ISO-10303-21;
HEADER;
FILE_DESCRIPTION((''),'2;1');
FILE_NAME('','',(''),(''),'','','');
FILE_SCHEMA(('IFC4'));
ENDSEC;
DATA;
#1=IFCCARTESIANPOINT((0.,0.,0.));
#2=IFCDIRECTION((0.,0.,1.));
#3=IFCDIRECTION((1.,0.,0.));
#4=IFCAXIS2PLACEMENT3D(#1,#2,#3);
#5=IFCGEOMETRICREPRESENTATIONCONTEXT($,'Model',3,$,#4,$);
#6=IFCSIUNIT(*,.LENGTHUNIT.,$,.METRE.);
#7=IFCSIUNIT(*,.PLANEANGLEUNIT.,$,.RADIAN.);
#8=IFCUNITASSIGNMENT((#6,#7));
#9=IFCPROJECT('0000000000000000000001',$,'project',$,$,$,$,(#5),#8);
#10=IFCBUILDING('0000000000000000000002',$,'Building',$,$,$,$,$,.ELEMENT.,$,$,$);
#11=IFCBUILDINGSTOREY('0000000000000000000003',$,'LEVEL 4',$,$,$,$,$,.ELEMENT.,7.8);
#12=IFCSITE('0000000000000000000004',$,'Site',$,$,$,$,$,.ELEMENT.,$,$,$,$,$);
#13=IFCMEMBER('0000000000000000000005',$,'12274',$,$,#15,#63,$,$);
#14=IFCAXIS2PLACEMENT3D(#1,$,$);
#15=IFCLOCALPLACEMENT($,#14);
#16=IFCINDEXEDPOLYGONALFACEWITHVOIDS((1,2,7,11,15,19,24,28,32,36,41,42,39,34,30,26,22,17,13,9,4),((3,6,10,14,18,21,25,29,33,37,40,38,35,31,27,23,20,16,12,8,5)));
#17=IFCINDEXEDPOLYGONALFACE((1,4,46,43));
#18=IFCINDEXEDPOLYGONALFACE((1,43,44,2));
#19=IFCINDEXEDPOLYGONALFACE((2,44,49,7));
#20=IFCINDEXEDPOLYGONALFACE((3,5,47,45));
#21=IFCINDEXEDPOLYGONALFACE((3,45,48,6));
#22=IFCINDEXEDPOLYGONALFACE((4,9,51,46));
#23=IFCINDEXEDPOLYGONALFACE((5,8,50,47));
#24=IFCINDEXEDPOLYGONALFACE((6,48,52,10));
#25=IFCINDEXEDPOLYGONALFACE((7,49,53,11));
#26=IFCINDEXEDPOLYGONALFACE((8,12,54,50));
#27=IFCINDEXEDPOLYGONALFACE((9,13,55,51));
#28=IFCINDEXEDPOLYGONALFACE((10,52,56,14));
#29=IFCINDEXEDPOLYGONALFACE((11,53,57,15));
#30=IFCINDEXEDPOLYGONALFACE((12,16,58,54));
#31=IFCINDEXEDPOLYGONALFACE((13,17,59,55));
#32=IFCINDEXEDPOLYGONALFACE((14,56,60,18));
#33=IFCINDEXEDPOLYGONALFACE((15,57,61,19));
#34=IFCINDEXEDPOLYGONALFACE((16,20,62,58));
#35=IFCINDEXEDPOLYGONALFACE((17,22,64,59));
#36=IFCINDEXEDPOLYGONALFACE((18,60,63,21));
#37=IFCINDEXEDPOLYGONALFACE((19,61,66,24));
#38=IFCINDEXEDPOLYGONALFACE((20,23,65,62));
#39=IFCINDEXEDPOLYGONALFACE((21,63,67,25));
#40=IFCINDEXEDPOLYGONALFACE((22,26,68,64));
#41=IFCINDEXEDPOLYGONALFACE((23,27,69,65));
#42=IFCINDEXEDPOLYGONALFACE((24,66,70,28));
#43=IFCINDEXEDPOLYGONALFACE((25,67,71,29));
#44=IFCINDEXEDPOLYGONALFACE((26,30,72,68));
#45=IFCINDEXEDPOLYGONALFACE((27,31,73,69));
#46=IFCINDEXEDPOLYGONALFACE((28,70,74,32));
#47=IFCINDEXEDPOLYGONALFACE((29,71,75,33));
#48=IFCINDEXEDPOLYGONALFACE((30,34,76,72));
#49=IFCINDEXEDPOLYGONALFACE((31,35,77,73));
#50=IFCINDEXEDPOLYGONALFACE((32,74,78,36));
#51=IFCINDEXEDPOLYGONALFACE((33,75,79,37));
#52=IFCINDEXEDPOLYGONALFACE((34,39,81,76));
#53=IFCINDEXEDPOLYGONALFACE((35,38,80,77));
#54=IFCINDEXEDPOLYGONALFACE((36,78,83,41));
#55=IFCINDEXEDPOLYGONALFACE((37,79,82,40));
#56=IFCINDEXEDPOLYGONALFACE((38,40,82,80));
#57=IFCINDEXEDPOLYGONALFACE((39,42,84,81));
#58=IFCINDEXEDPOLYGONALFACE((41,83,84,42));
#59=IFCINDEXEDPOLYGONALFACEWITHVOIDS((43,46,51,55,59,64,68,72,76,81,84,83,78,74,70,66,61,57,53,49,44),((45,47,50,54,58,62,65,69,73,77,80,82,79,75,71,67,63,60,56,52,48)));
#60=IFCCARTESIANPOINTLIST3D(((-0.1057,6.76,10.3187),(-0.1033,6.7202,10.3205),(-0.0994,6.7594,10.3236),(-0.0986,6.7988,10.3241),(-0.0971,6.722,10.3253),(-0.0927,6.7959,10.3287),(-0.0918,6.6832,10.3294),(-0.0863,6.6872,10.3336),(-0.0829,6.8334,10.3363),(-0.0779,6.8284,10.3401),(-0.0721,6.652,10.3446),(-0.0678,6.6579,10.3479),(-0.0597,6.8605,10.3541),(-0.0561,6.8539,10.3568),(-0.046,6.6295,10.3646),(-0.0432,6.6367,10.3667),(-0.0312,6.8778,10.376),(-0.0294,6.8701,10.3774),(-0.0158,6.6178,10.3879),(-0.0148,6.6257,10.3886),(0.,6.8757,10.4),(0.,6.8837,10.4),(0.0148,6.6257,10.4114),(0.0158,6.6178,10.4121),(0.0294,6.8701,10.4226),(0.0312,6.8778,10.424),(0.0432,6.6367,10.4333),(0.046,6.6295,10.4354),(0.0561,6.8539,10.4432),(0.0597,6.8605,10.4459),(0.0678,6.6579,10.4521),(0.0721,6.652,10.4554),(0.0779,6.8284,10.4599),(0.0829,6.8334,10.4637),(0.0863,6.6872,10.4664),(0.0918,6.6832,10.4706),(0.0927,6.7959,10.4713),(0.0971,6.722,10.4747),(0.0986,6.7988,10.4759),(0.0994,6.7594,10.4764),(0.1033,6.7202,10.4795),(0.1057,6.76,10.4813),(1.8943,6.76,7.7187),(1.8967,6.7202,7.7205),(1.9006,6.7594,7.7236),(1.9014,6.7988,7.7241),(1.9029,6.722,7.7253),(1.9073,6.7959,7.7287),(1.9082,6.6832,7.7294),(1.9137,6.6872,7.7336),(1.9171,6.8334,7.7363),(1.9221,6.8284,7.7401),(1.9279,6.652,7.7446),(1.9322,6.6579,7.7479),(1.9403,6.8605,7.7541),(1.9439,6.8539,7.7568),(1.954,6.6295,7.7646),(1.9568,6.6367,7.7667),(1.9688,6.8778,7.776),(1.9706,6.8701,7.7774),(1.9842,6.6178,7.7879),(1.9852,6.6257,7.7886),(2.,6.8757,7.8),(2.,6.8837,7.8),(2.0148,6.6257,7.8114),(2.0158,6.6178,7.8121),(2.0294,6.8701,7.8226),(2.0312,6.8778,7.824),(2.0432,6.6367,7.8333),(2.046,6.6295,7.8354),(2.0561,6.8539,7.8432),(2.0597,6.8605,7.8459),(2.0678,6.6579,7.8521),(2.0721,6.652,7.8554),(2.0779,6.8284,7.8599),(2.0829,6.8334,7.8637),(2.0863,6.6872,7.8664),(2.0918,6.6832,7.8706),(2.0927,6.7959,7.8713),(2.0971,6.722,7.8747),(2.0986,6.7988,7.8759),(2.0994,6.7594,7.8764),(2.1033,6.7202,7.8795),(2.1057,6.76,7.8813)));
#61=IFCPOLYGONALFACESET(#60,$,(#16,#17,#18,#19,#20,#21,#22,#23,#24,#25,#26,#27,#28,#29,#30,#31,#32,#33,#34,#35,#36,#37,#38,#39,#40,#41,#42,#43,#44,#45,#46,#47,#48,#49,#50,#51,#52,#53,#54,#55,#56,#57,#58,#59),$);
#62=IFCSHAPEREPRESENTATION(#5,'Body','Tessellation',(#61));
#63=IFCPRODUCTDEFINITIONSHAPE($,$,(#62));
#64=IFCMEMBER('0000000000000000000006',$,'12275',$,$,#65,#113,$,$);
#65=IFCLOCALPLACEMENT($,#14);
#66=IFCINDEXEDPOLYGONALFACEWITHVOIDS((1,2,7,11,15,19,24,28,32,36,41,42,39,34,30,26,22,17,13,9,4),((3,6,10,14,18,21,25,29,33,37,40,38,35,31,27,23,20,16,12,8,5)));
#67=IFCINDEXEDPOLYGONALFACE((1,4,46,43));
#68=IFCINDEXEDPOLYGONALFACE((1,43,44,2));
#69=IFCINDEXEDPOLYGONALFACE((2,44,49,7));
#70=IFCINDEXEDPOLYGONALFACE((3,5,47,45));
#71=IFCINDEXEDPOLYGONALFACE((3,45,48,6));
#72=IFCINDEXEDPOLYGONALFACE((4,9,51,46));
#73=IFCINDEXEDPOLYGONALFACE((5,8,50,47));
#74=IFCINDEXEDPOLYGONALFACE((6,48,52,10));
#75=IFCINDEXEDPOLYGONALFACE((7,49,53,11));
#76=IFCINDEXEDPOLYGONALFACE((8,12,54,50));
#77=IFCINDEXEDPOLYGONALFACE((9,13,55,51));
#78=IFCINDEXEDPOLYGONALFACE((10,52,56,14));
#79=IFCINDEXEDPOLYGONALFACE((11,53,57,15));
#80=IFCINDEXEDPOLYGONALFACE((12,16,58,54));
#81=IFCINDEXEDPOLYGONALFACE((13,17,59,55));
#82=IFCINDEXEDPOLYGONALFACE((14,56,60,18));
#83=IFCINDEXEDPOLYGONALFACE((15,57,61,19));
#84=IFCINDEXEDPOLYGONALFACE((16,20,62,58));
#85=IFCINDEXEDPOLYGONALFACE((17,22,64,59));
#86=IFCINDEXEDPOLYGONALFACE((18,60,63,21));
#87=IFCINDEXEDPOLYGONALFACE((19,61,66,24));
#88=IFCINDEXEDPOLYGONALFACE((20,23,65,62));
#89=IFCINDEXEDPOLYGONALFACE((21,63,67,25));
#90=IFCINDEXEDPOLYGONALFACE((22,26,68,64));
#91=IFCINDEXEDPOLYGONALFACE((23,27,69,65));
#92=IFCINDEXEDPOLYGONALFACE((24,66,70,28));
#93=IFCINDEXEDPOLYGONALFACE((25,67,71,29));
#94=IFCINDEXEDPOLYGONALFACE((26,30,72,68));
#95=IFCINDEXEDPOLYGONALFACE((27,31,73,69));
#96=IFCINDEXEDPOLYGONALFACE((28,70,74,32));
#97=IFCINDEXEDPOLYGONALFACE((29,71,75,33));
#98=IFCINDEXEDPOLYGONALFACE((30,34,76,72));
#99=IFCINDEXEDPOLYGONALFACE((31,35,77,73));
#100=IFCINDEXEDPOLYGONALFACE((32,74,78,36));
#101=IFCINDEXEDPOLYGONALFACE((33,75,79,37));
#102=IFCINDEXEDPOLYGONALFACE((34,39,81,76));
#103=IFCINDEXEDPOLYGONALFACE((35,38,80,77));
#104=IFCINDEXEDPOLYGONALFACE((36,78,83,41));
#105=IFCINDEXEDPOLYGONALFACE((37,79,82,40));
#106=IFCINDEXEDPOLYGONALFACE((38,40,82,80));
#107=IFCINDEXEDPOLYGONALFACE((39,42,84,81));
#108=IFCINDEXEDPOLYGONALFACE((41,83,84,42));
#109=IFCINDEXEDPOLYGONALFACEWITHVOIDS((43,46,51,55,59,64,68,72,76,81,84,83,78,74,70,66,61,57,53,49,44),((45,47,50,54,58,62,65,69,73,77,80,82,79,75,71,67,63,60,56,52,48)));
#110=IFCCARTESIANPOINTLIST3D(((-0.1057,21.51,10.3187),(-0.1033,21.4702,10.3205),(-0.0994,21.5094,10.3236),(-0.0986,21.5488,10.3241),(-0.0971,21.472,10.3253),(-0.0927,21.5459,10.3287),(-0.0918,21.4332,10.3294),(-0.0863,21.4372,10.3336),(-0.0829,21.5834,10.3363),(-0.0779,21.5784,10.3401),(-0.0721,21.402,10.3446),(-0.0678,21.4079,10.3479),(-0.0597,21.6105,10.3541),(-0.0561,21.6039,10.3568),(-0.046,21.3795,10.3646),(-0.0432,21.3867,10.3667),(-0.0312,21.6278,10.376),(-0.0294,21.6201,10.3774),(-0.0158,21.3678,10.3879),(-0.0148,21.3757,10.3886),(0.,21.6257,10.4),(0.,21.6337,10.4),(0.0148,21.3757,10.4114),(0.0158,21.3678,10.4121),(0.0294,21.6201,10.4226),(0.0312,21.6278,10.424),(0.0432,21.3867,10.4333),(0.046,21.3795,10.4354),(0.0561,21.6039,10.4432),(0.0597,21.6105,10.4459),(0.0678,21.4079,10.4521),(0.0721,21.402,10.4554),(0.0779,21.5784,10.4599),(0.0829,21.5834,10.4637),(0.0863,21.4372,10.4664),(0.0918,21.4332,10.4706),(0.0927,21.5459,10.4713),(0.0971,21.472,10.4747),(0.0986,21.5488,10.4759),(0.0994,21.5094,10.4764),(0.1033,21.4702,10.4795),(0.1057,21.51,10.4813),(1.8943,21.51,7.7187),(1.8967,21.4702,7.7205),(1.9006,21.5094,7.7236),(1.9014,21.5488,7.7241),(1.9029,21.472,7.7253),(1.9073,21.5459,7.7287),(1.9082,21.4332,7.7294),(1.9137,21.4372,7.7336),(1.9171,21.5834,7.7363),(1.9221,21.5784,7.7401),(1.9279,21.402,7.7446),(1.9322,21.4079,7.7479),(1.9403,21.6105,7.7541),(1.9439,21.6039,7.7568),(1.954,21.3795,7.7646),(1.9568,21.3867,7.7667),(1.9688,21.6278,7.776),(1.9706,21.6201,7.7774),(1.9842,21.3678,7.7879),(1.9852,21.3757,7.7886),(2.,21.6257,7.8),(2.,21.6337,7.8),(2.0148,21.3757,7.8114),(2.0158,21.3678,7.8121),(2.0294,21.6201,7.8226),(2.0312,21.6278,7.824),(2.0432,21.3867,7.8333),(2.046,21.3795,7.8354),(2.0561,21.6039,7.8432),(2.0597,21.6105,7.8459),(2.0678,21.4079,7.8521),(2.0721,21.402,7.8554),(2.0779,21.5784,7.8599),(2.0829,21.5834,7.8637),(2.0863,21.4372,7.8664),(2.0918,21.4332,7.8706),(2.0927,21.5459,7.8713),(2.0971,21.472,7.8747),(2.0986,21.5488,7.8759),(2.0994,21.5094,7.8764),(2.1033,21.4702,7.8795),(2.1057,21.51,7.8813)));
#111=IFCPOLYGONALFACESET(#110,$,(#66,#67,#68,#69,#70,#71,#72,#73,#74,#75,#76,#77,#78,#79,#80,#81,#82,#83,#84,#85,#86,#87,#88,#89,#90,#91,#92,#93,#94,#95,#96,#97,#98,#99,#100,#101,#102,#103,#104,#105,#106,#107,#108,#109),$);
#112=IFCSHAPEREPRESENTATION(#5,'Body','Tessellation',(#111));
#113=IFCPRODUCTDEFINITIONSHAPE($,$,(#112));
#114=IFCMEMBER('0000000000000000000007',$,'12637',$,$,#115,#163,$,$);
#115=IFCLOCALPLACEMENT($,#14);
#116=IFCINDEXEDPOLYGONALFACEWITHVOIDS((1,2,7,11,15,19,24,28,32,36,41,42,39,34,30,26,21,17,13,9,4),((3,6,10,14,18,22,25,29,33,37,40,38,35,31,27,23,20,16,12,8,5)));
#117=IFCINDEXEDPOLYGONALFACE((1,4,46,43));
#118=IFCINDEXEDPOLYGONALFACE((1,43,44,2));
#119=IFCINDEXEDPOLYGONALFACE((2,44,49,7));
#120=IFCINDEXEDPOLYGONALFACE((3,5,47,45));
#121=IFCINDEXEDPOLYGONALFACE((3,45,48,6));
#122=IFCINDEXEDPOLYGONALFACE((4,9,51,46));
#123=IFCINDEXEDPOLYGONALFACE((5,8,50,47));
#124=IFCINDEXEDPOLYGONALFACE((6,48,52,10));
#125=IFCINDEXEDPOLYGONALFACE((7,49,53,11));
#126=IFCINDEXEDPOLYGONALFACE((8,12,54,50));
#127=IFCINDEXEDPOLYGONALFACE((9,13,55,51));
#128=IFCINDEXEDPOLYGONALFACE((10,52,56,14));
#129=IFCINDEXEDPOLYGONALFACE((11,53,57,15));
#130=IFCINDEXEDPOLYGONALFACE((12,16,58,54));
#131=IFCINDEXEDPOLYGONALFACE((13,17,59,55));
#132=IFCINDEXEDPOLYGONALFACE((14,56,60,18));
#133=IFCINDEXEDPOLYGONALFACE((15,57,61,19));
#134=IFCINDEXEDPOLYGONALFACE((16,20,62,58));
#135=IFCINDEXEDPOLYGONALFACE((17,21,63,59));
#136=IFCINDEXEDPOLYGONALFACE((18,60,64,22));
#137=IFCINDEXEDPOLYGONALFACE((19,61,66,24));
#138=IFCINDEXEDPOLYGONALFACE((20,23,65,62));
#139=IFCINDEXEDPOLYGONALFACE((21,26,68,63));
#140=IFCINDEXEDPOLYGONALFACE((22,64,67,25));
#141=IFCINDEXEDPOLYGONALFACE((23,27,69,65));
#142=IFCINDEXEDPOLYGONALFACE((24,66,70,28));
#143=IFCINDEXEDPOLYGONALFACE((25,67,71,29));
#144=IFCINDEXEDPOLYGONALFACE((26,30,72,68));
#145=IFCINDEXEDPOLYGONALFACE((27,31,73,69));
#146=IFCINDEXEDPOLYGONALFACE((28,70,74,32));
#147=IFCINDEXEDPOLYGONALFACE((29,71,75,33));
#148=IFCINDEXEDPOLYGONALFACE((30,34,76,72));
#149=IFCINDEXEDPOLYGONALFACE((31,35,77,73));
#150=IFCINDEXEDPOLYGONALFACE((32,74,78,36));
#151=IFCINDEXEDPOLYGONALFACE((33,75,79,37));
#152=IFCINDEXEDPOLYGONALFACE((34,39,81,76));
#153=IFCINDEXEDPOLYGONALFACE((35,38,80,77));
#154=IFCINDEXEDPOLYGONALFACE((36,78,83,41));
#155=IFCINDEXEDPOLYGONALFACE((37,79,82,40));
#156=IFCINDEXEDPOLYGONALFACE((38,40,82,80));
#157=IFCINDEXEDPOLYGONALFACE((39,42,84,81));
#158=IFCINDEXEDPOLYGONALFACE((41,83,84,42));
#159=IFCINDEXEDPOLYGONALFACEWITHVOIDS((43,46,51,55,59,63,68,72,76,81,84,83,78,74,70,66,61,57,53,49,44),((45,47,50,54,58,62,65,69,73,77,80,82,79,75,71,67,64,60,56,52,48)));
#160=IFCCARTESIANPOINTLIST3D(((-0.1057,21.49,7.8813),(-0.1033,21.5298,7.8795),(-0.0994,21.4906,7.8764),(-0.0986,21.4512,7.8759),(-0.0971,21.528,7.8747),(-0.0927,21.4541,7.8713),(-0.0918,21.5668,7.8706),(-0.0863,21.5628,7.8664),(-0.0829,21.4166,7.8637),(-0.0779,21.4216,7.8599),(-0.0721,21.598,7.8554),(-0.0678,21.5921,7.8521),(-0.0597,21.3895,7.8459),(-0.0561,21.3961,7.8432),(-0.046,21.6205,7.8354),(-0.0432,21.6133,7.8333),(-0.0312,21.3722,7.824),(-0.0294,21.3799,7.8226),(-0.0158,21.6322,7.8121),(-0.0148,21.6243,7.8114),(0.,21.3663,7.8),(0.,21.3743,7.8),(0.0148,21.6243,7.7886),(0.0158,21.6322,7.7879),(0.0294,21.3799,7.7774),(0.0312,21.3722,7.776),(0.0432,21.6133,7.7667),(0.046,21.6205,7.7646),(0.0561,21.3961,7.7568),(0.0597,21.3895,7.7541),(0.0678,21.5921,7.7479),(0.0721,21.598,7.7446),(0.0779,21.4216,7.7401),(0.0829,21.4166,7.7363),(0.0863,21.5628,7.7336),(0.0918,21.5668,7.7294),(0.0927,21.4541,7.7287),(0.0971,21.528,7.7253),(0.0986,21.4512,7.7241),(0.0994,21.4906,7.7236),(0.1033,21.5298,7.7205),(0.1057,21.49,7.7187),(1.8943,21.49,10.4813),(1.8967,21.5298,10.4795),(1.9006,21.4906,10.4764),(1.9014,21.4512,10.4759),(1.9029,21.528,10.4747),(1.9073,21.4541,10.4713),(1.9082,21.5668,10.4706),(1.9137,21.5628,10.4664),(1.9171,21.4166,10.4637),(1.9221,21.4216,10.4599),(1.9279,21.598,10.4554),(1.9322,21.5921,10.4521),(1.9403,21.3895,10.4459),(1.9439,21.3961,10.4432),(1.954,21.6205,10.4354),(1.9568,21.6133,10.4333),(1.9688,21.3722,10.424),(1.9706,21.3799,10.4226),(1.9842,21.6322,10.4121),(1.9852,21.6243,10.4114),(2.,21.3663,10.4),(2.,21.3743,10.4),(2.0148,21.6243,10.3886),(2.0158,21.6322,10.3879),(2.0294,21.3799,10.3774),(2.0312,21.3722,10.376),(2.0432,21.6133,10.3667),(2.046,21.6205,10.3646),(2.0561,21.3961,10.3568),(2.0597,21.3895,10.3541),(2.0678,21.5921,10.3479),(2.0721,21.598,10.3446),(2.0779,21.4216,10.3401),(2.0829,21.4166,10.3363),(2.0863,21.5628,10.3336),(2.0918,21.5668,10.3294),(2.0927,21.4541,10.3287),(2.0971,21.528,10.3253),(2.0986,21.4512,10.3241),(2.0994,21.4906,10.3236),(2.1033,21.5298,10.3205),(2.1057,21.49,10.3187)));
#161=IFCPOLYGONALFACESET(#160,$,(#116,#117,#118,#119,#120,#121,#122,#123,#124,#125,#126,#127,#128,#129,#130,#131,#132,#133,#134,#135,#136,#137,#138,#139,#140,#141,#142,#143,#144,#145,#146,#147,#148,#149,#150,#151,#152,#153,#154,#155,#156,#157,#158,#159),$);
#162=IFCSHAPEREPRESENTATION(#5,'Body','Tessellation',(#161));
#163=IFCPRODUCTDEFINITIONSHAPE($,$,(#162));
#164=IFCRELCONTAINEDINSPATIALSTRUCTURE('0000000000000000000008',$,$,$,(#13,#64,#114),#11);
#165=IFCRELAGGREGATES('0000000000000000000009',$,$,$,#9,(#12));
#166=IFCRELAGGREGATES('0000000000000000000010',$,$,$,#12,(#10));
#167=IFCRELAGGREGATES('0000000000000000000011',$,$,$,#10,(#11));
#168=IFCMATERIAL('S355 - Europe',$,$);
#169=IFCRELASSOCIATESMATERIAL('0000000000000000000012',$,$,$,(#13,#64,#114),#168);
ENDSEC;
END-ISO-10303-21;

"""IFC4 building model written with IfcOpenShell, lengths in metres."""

from ifc_helpers import new_model, si_unit, frame, origin_with_axes, origin_2d_with_axis, place, context, project, spatial, hollow_circle, extrude, material, material_profile, profile_set, profile_usage, element, save


model = new_model("IFC4")

# Units and contexts
model_context = context("Model", 3, world=origin_with_axes())
ifc_project = project(units=[si_unit("LENGTHUNIT", "METRE"), si_unit("PLANEANGLEUNIT", "RADIAN")], contexts=[model_context])

# Site, building, storey
site = spatial("IfcSite", under=ifc_project, Name="Site", CompositionType="ELEMENT")
building = spatial("IfcBuilding", under=site, Name="Building", CompositionType="ELEMENT")
storey = spatial("IfcBuildingStorey", under=building, Name="LEVEL 4", CompositionType="ELEMENT", Elevation=7.8)

# Shared definitions
ifc_material = material(Name="S355 - Europe")

# Members
ifc_material_profile_1 = material_profile(ifc_material, hollow_circle(Radius=0.1337, WallThickness=0.008, at=origin_2d_with_axis()))
ifc_profile_set_1 = profile_set([ifc_material_profile_1])
ifc_profile_usage_1 = profile_usage(ifc_profile_set_1, cardinal=10)
member_1_placement = place(None, frame((0.0, 6.75, 10.4), z_axis=(0.609711, 0.0, -0.792624), x_axis=(0.0, 1.0, 0.0)))
element("IfcMember", 1, at=member_1_placement, inside=storey, material=ifc_profile_usage_1, Name="12274", context=model_context, shape_type="SweptSolid", body=[
    extrude(hollow_circle(Radius=0.1337, WallThickness=0.008, at=origin_2d_with_axis()), origin_with_axes(), (0.0, 0.0, 1.0), 3.2802),
])
ifc_material_profile_2 = material_profile(ifc_material, hollow_circle(Radius=0.1337, WallThickness=0.008, at=origin_2d_with_axis()))
ifc_profile_set_2 = profile_set([ifc_material_profile_2])
ifc_profile_usage_2 = profile_usage(ifc_profile_set_2, cardinal=10)
member_2_placement = place(None, frame((0.0, 21.5, 10.4), z_axis=(0.609711, 0.0, -0.792624), x_axis=(0.0, 1.0, 0.0)))
element("IfcMember", 2, at=member_2_placement, inside=storey, material=ifc_profile_usage_2, Name="12275", context=model_context, shape_type="SweptSolid", body=[
    extrude(hollow_circle(Radius=0.1337, WallThickness=0.008, at=origin_2d_with_axis()), origin_with_axes(), (0.0, 0.0, 1.0), 3.2802),
])
ifc_material_profile_3 = material_profile(ifc_material, hollow_circle(Radius=0.1337, WallThickness=0.008, at=origin_2d_with_axis()))
ifc_profile_set_3 = profile_set([ifc_material_profile_3])
ifc_profile_usage_3 = profile_usage(ifc_profile_set_3, cardinal=10)
member_3_placement = place(None, frame((2.0, 21.5, 10.4), z_axis=(-0.609711, 0.0, -0.792624), x_axis=(0.0, -1.0, 0.0)))
element("IfcMember", 3, at=member_3_placement, inside=storey, material=ifc_profile_usage_3, Name="12637", context=model_context, shape_type="SweptSolid", body=[
    extrude(hollow_circle(Radius=0.1337, WallThickness=0.008, at=origin_2d_with_axis()), origin_with_axes(), (0.0, 0.0, 1.0), 3.2802),
])

save(model, "model.ifc")
